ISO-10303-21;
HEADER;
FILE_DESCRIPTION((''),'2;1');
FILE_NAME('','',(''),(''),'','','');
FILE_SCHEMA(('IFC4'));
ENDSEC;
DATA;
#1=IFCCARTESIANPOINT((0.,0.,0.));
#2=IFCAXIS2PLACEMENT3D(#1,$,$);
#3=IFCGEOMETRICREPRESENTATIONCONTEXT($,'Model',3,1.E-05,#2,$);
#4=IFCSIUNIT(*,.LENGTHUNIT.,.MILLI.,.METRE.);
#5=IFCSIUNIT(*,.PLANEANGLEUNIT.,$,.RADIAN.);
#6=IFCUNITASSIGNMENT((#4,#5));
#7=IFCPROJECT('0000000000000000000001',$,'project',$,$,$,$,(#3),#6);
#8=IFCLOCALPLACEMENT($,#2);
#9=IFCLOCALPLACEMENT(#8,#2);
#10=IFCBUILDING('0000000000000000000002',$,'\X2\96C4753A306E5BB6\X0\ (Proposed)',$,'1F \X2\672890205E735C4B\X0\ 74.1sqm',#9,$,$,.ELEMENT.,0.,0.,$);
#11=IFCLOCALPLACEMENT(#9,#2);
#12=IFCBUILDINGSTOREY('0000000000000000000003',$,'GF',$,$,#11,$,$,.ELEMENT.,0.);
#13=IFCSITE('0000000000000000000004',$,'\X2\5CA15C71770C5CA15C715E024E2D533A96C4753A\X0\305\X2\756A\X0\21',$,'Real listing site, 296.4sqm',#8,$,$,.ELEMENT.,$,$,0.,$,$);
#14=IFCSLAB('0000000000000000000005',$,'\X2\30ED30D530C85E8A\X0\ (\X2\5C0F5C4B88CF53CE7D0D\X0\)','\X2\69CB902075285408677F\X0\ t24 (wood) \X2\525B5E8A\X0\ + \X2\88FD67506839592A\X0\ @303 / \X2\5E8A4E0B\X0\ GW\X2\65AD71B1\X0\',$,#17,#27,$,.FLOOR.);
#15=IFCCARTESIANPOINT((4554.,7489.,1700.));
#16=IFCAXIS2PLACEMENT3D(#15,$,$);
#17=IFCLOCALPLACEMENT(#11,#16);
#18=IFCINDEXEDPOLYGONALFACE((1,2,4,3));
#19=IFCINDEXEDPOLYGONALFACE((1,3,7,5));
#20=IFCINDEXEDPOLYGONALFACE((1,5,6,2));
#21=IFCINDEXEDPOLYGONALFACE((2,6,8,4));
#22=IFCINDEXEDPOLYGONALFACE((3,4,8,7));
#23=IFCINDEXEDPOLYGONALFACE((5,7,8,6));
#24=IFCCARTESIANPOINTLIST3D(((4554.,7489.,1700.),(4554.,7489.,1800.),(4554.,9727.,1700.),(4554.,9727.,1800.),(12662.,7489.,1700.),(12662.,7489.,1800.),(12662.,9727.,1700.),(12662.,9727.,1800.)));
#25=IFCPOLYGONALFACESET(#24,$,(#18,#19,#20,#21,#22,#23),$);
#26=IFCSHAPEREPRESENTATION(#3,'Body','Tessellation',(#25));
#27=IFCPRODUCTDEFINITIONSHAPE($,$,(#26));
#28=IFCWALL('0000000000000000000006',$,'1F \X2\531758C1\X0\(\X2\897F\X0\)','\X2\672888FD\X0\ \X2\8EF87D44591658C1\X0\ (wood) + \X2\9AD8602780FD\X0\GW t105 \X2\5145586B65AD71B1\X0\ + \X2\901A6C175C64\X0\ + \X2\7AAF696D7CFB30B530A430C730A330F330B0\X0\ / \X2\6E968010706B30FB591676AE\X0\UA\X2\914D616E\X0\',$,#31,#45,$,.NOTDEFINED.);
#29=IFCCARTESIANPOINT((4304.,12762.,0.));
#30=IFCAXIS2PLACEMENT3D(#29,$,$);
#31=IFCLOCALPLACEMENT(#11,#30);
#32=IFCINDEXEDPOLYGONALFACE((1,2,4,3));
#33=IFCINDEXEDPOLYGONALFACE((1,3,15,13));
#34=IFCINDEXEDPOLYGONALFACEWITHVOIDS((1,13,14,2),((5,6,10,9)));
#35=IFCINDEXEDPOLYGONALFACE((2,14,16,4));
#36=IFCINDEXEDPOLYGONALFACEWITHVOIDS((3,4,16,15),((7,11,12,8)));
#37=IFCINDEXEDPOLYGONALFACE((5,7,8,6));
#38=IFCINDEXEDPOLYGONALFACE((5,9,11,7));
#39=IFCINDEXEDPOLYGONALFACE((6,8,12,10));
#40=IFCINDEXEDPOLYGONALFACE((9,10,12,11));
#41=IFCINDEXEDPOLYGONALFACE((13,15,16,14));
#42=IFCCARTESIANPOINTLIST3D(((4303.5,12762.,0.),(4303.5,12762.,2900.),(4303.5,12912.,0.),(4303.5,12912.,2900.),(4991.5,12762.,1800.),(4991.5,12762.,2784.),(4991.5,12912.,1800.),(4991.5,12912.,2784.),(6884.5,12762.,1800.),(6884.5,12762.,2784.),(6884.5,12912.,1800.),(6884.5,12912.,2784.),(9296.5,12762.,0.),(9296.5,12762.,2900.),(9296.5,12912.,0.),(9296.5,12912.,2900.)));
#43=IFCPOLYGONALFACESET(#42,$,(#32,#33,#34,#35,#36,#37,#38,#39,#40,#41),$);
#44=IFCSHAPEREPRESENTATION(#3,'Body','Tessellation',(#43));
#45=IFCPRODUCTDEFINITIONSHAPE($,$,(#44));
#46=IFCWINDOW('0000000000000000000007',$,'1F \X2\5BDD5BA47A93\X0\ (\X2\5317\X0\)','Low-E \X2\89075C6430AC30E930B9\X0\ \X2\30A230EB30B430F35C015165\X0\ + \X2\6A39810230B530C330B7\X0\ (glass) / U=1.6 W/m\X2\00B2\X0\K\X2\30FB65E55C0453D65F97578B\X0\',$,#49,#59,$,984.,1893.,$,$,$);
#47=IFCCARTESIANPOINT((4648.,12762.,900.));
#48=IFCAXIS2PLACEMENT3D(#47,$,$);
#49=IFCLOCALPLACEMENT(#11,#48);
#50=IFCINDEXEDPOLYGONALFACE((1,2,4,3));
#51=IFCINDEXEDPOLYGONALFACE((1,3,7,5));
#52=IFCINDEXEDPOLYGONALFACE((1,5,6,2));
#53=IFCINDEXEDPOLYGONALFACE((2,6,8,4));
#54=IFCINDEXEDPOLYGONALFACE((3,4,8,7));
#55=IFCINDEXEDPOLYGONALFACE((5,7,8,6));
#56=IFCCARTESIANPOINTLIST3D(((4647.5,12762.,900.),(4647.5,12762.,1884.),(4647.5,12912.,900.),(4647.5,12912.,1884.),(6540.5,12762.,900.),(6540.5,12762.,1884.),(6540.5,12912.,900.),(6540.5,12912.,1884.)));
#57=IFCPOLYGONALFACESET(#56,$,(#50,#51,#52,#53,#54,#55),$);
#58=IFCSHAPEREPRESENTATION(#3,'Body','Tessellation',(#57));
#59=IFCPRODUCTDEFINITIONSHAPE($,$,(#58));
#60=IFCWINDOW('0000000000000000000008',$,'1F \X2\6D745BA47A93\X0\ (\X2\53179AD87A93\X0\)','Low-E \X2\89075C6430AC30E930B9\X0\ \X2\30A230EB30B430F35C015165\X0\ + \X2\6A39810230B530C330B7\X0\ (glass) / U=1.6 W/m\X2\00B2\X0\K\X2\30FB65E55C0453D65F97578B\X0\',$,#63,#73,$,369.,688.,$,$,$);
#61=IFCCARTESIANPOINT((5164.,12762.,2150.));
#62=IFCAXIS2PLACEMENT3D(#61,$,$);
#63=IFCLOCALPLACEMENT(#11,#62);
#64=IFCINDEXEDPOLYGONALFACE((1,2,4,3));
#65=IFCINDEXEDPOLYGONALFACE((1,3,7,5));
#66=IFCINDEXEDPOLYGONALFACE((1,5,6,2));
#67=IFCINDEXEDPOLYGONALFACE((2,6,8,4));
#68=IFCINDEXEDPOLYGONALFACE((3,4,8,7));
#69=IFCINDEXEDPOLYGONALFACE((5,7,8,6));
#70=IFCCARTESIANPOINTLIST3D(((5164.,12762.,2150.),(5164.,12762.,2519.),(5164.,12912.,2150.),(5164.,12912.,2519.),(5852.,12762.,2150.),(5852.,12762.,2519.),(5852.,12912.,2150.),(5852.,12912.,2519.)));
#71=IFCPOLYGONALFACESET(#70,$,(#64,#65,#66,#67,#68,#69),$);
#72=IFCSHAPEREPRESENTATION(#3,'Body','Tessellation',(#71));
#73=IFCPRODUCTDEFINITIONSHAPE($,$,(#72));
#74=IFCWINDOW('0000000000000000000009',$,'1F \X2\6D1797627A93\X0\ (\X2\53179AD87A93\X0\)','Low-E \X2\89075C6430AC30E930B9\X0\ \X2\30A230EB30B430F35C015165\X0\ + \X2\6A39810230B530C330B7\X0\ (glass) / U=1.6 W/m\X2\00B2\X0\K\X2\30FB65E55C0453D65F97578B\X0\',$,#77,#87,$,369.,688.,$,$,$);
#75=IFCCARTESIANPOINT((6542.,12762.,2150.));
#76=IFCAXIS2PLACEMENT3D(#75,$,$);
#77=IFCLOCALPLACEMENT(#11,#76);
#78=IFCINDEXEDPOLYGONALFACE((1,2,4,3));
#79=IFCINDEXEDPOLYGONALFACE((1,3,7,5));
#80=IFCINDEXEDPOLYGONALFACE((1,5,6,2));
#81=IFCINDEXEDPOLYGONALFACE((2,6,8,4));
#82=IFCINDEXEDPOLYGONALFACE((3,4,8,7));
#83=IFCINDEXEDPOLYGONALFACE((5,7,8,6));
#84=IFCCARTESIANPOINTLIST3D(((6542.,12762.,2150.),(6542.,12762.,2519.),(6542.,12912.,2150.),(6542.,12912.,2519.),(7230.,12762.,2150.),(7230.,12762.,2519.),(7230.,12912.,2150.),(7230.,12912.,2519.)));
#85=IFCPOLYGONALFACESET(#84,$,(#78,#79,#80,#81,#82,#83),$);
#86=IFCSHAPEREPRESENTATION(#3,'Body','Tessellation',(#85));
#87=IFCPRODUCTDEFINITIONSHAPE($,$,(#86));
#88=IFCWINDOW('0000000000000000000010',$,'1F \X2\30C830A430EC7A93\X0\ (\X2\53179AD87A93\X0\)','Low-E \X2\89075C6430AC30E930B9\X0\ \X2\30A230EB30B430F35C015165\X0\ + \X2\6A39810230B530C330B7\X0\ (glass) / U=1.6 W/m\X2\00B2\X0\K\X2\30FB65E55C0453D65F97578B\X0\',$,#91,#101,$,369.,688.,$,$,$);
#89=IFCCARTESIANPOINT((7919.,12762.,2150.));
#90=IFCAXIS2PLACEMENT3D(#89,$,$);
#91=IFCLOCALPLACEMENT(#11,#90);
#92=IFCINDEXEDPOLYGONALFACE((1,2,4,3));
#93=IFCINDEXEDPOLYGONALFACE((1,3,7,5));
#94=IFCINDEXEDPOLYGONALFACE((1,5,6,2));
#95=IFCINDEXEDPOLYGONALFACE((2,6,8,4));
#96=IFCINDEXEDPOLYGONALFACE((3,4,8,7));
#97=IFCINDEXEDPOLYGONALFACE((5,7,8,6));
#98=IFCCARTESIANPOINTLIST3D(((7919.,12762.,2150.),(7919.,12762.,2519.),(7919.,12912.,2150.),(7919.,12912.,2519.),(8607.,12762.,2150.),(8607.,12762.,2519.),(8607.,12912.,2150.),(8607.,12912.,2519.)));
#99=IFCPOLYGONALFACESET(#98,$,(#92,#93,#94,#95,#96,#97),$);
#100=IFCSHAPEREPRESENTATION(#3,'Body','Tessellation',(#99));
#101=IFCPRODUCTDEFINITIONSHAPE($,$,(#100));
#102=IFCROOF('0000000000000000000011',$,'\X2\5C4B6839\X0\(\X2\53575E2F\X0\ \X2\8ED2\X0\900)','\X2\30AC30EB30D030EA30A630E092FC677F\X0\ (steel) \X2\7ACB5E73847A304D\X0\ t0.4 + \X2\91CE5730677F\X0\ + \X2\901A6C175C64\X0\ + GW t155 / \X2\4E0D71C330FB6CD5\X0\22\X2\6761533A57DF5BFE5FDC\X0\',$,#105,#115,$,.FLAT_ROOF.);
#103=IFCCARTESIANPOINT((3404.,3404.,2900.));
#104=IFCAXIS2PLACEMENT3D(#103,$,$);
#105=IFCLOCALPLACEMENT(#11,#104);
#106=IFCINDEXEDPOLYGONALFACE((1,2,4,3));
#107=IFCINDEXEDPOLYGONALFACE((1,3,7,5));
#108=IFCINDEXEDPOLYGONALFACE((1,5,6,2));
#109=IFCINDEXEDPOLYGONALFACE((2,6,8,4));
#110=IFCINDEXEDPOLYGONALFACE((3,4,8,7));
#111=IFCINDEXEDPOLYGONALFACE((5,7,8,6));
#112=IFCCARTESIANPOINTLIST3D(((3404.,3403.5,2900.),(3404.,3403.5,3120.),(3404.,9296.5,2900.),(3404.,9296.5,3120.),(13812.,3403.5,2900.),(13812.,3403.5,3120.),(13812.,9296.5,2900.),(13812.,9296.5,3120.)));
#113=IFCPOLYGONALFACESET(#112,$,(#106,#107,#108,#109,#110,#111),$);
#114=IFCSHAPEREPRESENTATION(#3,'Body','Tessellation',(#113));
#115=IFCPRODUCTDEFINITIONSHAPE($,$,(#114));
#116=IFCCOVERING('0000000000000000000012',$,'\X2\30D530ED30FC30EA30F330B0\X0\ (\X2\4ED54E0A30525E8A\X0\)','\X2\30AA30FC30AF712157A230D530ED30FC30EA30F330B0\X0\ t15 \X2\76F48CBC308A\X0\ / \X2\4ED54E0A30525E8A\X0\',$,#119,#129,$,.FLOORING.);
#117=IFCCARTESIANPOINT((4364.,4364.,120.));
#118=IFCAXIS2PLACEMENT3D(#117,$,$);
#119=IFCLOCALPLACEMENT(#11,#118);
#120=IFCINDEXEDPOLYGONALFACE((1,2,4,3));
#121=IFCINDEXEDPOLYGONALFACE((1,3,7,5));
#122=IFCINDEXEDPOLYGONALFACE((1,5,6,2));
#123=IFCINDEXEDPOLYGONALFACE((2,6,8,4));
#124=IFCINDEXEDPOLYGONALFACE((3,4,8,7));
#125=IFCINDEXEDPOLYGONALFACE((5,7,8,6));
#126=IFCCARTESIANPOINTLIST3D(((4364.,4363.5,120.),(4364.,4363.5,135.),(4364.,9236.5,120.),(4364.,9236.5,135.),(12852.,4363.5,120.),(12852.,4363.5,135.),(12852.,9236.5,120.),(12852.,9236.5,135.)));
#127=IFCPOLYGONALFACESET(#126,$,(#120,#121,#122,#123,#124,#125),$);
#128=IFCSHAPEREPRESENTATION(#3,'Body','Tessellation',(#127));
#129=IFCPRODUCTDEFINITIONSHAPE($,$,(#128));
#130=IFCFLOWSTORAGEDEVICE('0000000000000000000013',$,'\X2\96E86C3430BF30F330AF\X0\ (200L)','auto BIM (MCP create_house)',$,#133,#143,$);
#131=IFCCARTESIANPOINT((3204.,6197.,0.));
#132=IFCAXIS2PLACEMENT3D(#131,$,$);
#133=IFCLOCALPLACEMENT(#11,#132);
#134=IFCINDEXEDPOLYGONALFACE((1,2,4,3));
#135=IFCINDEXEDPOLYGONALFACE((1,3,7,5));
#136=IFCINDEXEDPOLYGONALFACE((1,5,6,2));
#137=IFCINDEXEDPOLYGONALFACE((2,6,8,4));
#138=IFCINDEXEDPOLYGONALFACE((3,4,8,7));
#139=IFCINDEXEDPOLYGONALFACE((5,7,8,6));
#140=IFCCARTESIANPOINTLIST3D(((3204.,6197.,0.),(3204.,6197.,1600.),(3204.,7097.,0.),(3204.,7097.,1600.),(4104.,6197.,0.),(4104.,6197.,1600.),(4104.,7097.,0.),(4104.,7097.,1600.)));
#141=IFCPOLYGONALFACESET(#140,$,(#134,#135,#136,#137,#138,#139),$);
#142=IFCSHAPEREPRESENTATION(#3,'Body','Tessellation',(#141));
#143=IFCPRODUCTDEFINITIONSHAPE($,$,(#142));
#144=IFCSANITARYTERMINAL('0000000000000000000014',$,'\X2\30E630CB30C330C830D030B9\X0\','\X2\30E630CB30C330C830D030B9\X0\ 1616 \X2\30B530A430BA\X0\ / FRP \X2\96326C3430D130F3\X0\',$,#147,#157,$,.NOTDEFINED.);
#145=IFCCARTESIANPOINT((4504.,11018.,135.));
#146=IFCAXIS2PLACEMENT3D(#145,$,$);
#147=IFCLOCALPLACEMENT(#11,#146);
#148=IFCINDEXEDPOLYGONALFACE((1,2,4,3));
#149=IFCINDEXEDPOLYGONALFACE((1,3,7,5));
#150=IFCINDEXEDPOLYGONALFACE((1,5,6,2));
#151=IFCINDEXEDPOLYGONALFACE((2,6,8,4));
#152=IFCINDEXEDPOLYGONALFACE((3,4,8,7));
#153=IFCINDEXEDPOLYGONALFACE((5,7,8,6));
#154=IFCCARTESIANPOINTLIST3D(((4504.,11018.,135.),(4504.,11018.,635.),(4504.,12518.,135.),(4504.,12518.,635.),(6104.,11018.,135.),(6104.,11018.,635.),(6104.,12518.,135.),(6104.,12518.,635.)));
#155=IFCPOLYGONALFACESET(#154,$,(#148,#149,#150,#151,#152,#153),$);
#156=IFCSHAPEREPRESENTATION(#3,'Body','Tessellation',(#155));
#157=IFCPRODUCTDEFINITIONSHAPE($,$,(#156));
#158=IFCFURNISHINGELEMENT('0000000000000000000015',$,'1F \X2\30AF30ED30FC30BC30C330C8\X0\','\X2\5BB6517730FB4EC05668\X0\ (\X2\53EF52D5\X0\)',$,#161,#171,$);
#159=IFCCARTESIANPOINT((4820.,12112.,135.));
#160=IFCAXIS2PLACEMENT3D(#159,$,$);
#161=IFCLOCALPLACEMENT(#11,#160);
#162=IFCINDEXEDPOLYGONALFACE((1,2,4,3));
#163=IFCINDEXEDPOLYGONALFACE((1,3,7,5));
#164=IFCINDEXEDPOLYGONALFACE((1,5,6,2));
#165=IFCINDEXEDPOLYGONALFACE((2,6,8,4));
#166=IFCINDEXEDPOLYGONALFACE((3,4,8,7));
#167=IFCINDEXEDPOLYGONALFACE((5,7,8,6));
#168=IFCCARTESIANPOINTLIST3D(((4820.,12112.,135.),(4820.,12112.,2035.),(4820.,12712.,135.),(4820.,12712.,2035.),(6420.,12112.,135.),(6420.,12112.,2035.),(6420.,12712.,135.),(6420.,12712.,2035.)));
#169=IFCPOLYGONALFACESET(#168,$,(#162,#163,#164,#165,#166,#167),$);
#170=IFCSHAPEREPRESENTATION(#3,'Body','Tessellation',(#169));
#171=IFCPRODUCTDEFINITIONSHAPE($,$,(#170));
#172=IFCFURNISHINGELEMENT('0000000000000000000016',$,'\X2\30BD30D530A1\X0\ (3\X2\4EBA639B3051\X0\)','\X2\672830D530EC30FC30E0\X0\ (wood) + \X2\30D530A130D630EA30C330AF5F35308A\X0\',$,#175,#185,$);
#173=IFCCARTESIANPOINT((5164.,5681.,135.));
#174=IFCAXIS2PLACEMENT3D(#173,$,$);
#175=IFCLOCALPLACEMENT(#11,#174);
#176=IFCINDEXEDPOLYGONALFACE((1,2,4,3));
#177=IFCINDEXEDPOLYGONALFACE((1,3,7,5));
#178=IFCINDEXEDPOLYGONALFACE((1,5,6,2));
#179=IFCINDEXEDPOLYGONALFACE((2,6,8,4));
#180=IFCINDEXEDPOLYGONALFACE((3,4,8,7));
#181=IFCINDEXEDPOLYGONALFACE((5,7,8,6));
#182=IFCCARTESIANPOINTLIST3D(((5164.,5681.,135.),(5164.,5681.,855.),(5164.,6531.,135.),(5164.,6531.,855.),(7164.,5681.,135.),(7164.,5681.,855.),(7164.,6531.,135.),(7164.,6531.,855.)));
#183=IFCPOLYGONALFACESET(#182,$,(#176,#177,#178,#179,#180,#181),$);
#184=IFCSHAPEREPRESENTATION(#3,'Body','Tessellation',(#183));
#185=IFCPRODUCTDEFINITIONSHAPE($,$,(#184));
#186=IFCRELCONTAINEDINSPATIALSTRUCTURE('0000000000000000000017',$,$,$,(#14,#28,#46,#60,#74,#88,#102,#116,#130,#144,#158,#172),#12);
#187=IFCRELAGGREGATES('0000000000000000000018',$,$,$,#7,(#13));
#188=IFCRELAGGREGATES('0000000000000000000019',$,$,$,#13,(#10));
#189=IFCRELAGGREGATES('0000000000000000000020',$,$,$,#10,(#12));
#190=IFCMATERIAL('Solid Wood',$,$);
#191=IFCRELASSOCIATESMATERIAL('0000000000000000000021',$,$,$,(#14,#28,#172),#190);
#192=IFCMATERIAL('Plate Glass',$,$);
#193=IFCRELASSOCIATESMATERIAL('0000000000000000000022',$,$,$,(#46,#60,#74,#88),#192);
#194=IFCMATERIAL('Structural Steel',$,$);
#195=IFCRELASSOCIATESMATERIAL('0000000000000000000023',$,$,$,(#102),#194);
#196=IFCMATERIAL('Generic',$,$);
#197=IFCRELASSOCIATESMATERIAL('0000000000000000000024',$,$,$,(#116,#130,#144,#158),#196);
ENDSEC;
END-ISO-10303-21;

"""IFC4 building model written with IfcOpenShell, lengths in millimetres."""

from ifc_helpers import new_model, si_unit, frame, frame_2d, origin, place, context, project, spatial, rectangle, extrude, material, element, fill, save


model = new_model("IFC4")

# Units and contexts
model_context = context("Model", 3, precision=1e-05, world=origin())
ifc_project = project(units=[si_unit("LENGTHUNIT", "METRE", prefix="MILLI"), si_unit("PLANEANGLEUNIT", "RADIAN")], contexts=[model_context])

# Site, building, storey
site_placement = place(None, origin())
site = spatial("IfcSite", under=ifc_project, at=site_placement, Name="岡山県岡山市中区雄町305番21", ObjectType="Real listing site, 296.4sqm", CompositionType="ELEMENT", RefElevation=0.0)
building_placement = place(site_placement, origin())
building = spatial("IfcBuilding", under=site, at=building_placement, Name="雄町の家 (Proposed)", ObjectType="1F 木造平屋 74.1sqm", CompositionType="ELEMENT", ElevationOfRefHeight=0.0, ElevationOfTerrain=0.0)
storey_placement = place(building_placement, origin())
storey = spatial("IfcBuildingStorey", under=building, at=storey_placement, Name="GF", CompositionType="ELEMENT", Elevation=0.0)

# Slab
ifc_material_1 = material(Name="Solid Wood")
slab_1_placement = place(storey_placement, frame((4554.0, 7489.0, 1700.0)))
element("IfcSlab", 1, at=slab_1_placement, inside=storey, material=ifc_material_1, Name="ロフト床 (小屋裏収納)", Description="構造用合板 t24 (wood) 剛床 + 製材根太 @303 / 床下 GW断熱", PredefinedType="FLOOR", context=model_context, shape_type="SweptSolid", body=[
    extrude(rectangle(XDim=8108.0, YDim=2238.0, at=frame_2d((4054.0, 1119.0))), frame((4554.0, 7489.0, 1700.0)), (0.0, 0.0, 1.0), 100.0),
])

# Shared definitions
ifc_material_2 = material(Name="Plate Glass")

# Wall, openings, windows
wall_1_placement = place(storey_placement, frame((4304.0, 12762.0, 0.0)))
wall_1 = element("IfcWall", 2, at=wall_1_placement, inside=storey, material=ifc_material_1, Name="1F 北壁(西)", Description="木製 軸組外壁 (wood) + 高性能GW t105 充填断熱 + 通気層 + 窯業系サイディング / 準耐火・外皮UA配慮", PredefinedType="NOTDEFINED", context=model_context, shape_type="SweptSolid", body=[
    extrude(rectangle(XDim=4993.0, YDim=150.0, at=frame_2d((2496.0, 75.0))), frame((4304.0, 12762.0, 0.0)), (0.0, 0.0, 1.0), 2900.0),
])
opening_1_placement = place(storey_placement, frame((4648.0, 12762.0, 900.0)))
opening_1 = element("IfcOpeningElement", 3, at=opening_1_placement, cuts=wall_1, PredefinedType="NOTDEFINED", context=model_context, shape_type="SweptSolid", body=[
    extrude(rectangle(XDim=1893.0, YDim=150.0, at=frame_2d((946.0, 75.0))), frame((4648.0, 12762.0, 900.0)), (0.0, 0.0, 1.0), 984.0),
])
opening_2_placement = place(storey_placement, frame((5164.0, 12762.0, 2150.0)))
opening_2 = element("IfcOpeningElement", 4, at=opening_2_placement, cuts=wall_1, PredefinedType="NOTDEFINED", context=model_context, shape_type="SweptSolid", body=[
    extrude(rectangle(XDim=688.0, YDim=150.0, at=frame_2d((344.0, 75.0))), frame((5164.0, 12762.0, 2150.0)), (0.0, 0.0, 1.0), 369.0),
])
opening_3_placement = place(storey_placement, frame((6542.0, 12762.0, 2150.0)))
opening_3 = element("IfcOpeningElement", 5, at=opening_3_placement, cuts=wall_1, PredefinedType="NOTDEFINED", context=model_context, shape_type="SweptSolid", body=[
    extrude(rectangle(XDim=688.0, YDim=150.0, at=frame_2d((344.0, 75.0))), frame((6542.0, 12762.0, 2150.0)), (0.0, 0.0, 1.0), 369.0),
])
opening_4_placement = place(storey_placement, frame((7919.0, 12762.0, 2150.0)))
opening_4 = element("IfcOpeningElement", 6, at=opening_4_placement, cuts=wall_1, PredefinedType="NOTDEFINED", context=model_context, shape_type="SweptSolid", body=[
    extrude(rectangle(XDim=688.0, YDim=150.0, at=frame_2d((344.0, 75.0))), frame((7919.0, 12762.0, 2150.0)), (0.0, 0.0, 1.0), 369.0),
])
window_1_placement = place(storey_placement, frame((4648.0, 12762.0, 900.0)))
window_1 = element("IfcWindow", 7, at=window_1_placement, inside=storey, material=ifc_material_2, Name="1F 寝室窓 (北)", Description="Low-E 複層ガラス アルゴン封入 + 樹脂サッシ (glass) / U=1.6 W/m²K・日射取得型", OverallHeight=984.0, OverallWidth=1893.0, context=model_context, shape_type="SweptSolid", body=[
    extrude(rectangle(XDim=1893.0, YDim=150.0, at=frame_2d((946.0, 75.0))), frame((4648.0, 12762.0, 900.0)), (0.0, 0.0, 1.0), 984.0),
])
fill(opening_1, window_1)
window_2_placement = place(storey_placement, frame((5164.0, 12762.0, 2150.0)))
window_2 = element("IfcWindow", 8, at=window_2_placement, inside=storey, material=ifc_material_2, Name="1F 浴室窓 (北高窓)", Description="Low-E 複層ガラス アルゴン封入 + 樹脂サッシ (glass) / U=1.6 W/m²K・日射取得型", OverallHeight=369.0, OverallWidth=688.0, context=model_context, shape_type="SweptSolid", body=[
    extrude(rectangle(XDim=688.0, YDim=150.0, at=frame_2d((344.0, 75.0))), frame((5164.0, 12762.0, 2150.0)), (0.0, 0.0, 1.0), 369.0),
])
fill(opening_2, window_2)
window_3_placement = place(storey_placement, frame((6542.0, 12762.0, 2150.0)))
window_3 = element("IfcWindow", 9, at=window_3_placement, inside=storey, material=ifc_material_2, Name="1F 洗面窓 (北高窓)", Description="Low-E 複層ガラス アルゴン封入 + 樹脂サッシ (glass) / U=1.6 W/m²K・日射取得型", OverallHeight=369.0, OverallWidth=688.0, context=model_context, shape_type="SweptSolid", body=[
    extrude(rectangle(XDim=688.0, YDim=150.0, at=frame_2d((344.0, 75.0))), frame((6542.0, 12762.0, 2150.0)), (0.0, 0.0, 1.0), 369.0),
])
fill(opening_3, window_3)
window_4_placement = place(storey_placement, frame((7919.0, 12762.0, 2150.0)))
window_4 = element("IfcWindow", 10, at=window_4_placement, inside=storey, material=ifc_material_2, Name="1F トイレ窓 (北高窓)", Description="Low-E 複層ガラス アルゴン封入 + 樹脂サッシ (glass) / U=1.6 W/m²K・日射取得型", OverallHeight=369.0, OverallWidth=688.0, context=model_context, shape_type="SweptSolid", body=[
    extrude(rectangle(XDim=688.0, YDim=150.0, at=frame_2d((344.0, 75.0))), frame((7919.0, 12762.0, 2150.0)), (0.0, 0.0, 1.0), 369.0),
])
fill(opening_4, window_4)

# Roof
ifc_material_3 = material(Name="Structural Steel")
roof_1_placement = place(storey_placement, frame((3404.0, 3404.0, 2900.0)))
element("IfcRoof", 11, at=roof_1_placement, inside=storey, material=ifc_material_3, Name="屋根(南帯 軒900)", Description="ガルバリウム鋼板 (steel) 立平葺き t0.4 + 野地板 + 通気層 + GW t155 / 不燃・法22条区域対応", PredefinedType="FLAT_ROOF", context=model_context, shape_type="SweptSolid", body=[
    extrude(rectangle(XDim=10408.0, YDim=5893.0, at=frame_2d((5204.0, 2946.0))), frame((3404.0, 3404.0, 2900.0)), (0.0, 0.0, 1.0), 220.0),
])

# Covering
ifc_material_4 = material(Name="Generic")
covering_1_placement = place(storey_placement, frame((4364.0, 4364.0, 120.0)))
element("IfcCovering", 12, at=covering_1_placement, inside=storey, material=ifc_material_4, Name="フローリング (仕上げ床)", Description="オーク無垢フローリング t15 直貼り / 仕上げ床", PredefinedType="FLOORING", context=model_context, shape_type="SweptSolid", body=[
    extrude(rectangle(XDim=8488.0, YDim=4873.0, at=frame_2d((4244.0, 2436.0))), frame((4364.0, 4364.0, 120.0)), (0.0, 0.0, 1.0), 15.0),
])

# Flow storage device
flow_storage_device_placement = place(storey_placement, frame((3204.0, 6197.0, 0.0)))
element("IfcFlowStorageDevice", 13, at=flow_storage_device_placement, inside=storey, material=ifc_material_4, Name="雨水タンク (200L)", Description="auto BIM (MCP create_house)", context=model_context, shape_type="SweptSolid", body=[
    extrude(rectangle(XDim=900.0, YDim=900.0, at=frame_2d((450.0, 450.0))), frame((3204.0, 6197.0, 0.0)), (0.0, 0.0, 1.0), 1600.0),
])

# Sanitary terminal
sanitary_terminal_placement = place(storey_placement, frame((4504.0, 11018.0, 135.0)))
element("IfcSanitaryTerminal", 14, at=sanitary_terminal_placement, inside=storey, material=ifc_material_4, Name="ユニットバス", Description="ユニットバス 1616 サイズ / FRP 防水パン", PredefinedType="NOTDEFINED", context=model_context, shape_type="SweptSolid", body=[
    extrude(rectangle(XDim=1600.0, YDim=1500.0, at=frame_2d((800.0, 750.0))), frame((4504.0, 11018.0, 135.0)), (0.0, 0.0, 1.0), 500.0),
])

# Furnishing elements
furnishing_1_placement = place(storey_placement, frame((4820.0, 12112.0, 135.0)))
element("IfcFurnishingElement", 15, at=furnishing_1_placement, inside=storey, material=ifc_material_4, Name="1F クローゼット", Description="家具・什器 (可動)", context=model_context, shape_type="SweptSolid", body=[
    extrude(rectangle(XDim=1600.0, YDim=600.0, at=frame_2d((800.0, 300.0))), frame((4820.0, 12112.0, 135.0)), (0.0, 0.0, 1.0), 1900.0),
])
furnishing_2_placement = place(storey_placement, frame((5164.0, 5681.0, 135.0)))
element("IfcFurnishingElement", 16, at=furnishing_2_placement, inside=storey, material=ifc_material_1, Name="ソファ (3人掛け)", Description="木フレーム (wood) + ファブリック張り", context=model_context, shape_type="SweptSolid", body=[
    extrude(rectangle(XDim=2000.0, YDim=850.0, at=frame_2d((1000.0, 425.0))), frame((5164.0, 5681.0, 135.0)), (0.0, 0.0, 1.0), 720.0),
])

save(model, "model.ifc")
